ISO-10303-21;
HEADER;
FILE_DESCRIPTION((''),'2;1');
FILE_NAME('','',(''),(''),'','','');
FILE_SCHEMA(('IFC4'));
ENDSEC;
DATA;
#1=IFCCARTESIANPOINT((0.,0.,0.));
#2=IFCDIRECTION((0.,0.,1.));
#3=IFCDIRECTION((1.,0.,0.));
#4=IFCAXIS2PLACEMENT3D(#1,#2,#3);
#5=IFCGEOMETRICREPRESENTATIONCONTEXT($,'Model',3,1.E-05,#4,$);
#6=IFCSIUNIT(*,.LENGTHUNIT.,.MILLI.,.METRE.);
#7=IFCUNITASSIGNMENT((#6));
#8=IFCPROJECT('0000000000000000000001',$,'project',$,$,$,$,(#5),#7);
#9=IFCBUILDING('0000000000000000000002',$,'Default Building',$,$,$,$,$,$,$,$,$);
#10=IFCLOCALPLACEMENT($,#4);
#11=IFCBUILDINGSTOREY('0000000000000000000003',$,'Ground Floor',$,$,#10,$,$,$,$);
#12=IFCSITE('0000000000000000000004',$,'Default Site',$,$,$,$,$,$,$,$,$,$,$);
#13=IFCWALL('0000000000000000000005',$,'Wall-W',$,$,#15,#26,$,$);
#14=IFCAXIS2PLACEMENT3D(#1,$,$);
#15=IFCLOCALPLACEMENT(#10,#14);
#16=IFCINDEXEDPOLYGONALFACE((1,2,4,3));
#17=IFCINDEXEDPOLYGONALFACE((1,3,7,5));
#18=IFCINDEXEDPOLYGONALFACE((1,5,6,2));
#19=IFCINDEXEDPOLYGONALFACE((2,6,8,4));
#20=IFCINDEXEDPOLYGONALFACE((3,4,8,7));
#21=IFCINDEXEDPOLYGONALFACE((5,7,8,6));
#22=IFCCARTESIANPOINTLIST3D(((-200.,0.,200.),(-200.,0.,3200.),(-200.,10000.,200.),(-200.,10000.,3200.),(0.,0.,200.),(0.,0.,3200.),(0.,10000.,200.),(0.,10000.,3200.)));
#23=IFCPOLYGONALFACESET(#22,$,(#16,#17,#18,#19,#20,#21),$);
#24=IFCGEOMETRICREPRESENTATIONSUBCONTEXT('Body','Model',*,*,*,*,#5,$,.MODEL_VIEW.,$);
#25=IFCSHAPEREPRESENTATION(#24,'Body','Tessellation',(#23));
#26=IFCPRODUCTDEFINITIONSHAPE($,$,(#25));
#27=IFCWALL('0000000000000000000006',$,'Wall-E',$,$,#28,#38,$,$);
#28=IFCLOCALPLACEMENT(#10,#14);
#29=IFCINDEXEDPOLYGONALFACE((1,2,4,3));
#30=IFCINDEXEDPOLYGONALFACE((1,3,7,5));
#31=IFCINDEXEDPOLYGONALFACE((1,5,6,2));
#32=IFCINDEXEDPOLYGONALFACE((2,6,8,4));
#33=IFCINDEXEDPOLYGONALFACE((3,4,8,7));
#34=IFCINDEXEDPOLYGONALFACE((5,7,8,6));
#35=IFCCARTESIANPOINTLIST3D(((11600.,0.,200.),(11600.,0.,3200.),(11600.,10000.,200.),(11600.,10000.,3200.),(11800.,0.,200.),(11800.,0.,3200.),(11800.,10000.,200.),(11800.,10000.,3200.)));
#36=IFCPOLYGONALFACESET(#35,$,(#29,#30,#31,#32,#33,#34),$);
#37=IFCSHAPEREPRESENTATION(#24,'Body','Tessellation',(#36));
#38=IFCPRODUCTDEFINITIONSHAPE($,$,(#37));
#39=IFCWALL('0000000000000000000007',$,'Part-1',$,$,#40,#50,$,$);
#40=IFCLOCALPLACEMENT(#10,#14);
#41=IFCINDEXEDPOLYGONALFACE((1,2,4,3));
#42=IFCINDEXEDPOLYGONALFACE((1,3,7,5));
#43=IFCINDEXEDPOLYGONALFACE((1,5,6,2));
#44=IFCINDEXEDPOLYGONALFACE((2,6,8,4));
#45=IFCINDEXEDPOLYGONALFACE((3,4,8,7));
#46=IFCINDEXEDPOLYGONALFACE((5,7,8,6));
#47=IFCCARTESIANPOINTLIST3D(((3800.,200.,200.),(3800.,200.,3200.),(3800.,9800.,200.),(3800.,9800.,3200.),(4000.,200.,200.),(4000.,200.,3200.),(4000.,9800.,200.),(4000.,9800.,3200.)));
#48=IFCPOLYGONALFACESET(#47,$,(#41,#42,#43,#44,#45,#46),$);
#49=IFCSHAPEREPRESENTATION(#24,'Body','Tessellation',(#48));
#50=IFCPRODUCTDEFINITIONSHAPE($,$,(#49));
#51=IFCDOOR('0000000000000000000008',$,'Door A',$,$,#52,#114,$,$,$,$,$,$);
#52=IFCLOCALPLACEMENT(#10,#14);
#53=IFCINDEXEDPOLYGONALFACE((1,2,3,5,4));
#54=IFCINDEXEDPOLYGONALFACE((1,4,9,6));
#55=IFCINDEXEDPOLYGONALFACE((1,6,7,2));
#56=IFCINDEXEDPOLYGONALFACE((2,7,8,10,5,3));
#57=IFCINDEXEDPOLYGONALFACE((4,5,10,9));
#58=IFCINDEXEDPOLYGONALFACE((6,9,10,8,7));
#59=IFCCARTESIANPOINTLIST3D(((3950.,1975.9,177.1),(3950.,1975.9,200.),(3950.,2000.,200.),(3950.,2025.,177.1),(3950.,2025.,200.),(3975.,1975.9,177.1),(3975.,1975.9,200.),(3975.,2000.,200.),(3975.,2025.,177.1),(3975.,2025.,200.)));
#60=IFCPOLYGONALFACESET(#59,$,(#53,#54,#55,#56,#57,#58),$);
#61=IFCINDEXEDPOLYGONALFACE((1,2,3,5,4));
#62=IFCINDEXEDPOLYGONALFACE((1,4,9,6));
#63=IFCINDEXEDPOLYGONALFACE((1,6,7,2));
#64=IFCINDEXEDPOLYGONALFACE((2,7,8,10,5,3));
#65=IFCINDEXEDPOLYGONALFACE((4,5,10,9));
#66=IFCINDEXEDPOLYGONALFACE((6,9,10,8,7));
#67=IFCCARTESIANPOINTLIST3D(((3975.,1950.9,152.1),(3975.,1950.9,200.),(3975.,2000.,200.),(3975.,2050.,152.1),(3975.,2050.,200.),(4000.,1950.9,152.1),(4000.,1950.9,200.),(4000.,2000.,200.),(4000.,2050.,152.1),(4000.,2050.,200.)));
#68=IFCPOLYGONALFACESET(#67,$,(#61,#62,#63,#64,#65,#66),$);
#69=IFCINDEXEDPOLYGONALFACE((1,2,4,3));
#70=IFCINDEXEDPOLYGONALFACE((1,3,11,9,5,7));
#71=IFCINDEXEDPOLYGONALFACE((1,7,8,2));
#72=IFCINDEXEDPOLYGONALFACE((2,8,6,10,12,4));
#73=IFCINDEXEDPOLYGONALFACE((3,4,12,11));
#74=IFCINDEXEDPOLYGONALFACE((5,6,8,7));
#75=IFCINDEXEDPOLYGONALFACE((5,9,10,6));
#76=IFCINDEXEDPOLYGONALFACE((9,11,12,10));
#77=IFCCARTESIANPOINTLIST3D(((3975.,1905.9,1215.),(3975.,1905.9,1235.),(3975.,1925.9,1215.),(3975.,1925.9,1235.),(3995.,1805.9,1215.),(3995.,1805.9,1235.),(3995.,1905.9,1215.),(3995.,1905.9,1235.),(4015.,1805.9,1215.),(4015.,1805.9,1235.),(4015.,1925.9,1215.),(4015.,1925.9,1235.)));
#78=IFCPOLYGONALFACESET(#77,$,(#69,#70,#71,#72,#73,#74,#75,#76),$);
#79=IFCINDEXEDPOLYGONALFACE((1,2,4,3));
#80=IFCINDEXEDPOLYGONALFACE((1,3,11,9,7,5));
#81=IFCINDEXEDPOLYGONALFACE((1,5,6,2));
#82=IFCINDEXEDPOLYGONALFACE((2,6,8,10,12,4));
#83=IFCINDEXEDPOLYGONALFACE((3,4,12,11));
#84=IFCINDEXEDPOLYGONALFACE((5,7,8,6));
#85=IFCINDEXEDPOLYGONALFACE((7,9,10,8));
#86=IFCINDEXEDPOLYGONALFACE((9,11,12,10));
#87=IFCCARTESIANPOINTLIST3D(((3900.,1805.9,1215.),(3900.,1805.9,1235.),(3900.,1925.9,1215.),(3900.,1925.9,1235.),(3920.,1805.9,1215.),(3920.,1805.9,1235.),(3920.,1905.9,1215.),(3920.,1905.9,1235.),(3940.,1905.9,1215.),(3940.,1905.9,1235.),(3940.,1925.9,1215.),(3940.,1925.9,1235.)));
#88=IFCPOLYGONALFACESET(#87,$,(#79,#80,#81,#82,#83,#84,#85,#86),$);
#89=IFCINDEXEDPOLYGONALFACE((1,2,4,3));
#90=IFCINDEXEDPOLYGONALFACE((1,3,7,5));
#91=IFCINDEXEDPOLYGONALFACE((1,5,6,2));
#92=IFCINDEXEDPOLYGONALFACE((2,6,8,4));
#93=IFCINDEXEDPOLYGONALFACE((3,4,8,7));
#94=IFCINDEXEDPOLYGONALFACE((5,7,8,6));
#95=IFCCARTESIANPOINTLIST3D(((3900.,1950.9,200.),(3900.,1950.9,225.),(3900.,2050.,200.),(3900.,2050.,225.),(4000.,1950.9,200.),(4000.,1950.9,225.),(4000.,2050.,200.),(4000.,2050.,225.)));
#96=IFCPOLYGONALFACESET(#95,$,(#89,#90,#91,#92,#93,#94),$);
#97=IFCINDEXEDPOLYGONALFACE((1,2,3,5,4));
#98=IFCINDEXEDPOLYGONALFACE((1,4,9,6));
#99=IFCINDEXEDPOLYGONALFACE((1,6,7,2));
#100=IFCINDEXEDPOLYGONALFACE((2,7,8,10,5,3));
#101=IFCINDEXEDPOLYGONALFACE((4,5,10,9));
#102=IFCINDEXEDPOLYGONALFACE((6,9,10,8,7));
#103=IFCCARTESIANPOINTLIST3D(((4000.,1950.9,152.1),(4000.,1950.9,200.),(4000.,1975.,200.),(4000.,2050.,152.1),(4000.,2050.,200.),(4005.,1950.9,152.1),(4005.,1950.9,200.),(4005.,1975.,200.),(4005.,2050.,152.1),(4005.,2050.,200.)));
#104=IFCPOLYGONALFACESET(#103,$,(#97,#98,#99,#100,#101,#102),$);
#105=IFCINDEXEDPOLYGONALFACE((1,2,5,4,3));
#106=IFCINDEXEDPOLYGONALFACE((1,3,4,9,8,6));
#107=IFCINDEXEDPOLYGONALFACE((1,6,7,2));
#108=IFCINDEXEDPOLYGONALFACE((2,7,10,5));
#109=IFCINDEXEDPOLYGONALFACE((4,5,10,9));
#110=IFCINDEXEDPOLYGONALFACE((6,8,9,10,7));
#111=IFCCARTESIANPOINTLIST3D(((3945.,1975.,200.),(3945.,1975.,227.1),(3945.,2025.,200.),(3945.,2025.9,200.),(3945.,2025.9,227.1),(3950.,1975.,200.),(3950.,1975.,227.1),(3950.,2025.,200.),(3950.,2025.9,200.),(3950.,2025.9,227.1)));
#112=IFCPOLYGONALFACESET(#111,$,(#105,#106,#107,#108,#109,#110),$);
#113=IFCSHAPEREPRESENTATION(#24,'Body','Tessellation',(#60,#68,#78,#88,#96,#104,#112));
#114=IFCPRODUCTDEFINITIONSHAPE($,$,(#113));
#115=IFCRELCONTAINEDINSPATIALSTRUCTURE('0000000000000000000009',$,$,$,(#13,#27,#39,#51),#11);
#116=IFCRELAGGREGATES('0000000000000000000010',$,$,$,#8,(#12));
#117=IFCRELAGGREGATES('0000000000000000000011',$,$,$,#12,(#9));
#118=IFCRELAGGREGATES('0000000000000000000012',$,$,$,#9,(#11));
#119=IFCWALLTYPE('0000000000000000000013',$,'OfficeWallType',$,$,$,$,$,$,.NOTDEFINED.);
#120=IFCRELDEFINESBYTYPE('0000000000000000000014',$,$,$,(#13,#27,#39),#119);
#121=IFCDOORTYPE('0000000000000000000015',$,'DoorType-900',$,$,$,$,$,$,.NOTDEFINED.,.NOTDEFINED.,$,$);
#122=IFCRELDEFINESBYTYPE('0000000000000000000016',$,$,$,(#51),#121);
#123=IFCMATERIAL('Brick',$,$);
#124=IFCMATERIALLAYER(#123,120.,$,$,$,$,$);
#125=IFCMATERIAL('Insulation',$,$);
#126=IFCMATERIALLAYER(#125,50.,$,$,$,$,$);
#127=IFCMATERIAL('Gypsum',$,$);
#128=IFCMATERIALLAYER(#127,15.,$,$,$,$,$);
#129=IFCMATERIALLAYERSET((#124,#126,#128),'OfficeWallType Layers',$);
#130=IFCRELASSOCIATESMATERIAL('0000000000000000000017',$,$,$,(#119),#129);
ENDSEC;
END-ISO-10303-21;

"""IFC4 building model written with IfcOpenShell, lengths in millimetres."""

from ifc_helpers import new_model, si_unit, frame, origin_with_axes, place, context, subcontext, project, spatial, line, indexed_curve, outline, extrude, material, layer, layer_set, type_object, element, fill, save


model = new_model("IFC4")

# Units and contexts
model_context = context("Model", 3, precision=1e-05, world=origin_with_axes())
body_context = subcontext(model_context, "Body", "Model", "MODEL_VIEW")
ifc_project = project(units=[si_unit("LENGTHUNIT", "METRE", prefix="MILLI")], contexts=[model_context])

# Site, building, storey
site = spatial("IfcSite", under=ifc_project, Name="Default Site")
building = spatial("IfcBuilding", under=site, Name="Default Building")
storey_placement = place(None, origin_with_axes())
storey = spatial("IfcBuildingStorey", under=building, at=storey_placement, Name="Ground Floor")

# Shared definitions
ifc_material_1 = material(Name="Brick")
ifc_layer_1 = layer(ifc_material_1, 120.0)
ifc_material_2 = material(Name="Insulation")
ifc_layer_2 = layer(ifc_material_2, 50.0)
ifc_material_3 = material(Name="Gypsum")
ifc_layer_3 = layer(ifc_material_3, 15.0)
ifc_layer_set_1 = layer_set([ifc_layer_1, ifc_layer_2, ifc_layer_3], Name="OfficeWallType Layers")
wall_type = type_object("IfcWallType", Name="OfficeWallType", PredefinedType="NOTDEFINED", material=ifc_layer_set_1)
door_type = type_object("IfcDoorType", Name="DoorType-900", OperationType="NOTDEFINED", PredefinedType="NOTDEFINED")

# Walls
wall_1_placement = place(storey_placement, frame((0.0, 0.0, 200.0), z_axis=(0.0, 0.0, 1.0), x_axis=(1.0, 0.0, 0.0)))
element("IfcWall", 1, at=wall_1_placement, inside=storey, type_object=wall_type, Name="Wall-W", context=body_context, shape_type="SweptSolid", body=[
    extrude(outline(indexed_curve([(0.0, 0.0), (0.0, 10000.0), (-200.0, 10000.0), (-200.0, 0.0), (0.0, 0.0)])), None, (0.0, 0.0, 1.0), 3000.0),
])
wall_2_placement = place(storey_placement, frame((0.0, 0.0, 200.0), z_axis=(0.0, 0.0, 1.0), x_axis=(1.0, 0.0, 0.0)))
element("IfcWall", 2, at=wall_2_placement, inside=storey, type_object=wall_type, Name="Wall-E", context=body_context, shape_type="SweptSolid", body=[
    extrude(outline(indexed_curve([(11800.0, 0.0), (11800.0, 10000.0), (11600.0, 10000.0), (11600.0, 0.0), (11800.0, 0.0)])), None, (0.0, 0.0, 1.0), 3000.0),
])

# Wall, opening, door
wall_3_placement = place(storey_placement, frame((0.0, 0.0, 200.0), z_axis=(0.0, 0.0, 1.0), x_axis=(1.0, 0.0, 0.0)))
wall_3 = element("IfcWall", 3, at=wall_3_placement, inside=storey, type_object=wall_type, Name="Part-1", context=body_context, shape_type="SweptSolid", body=[
    extrude(outline(indexed_curve([(4000.0, 200.0), (4000.0, 9800.0), (3800.0, 9800.0), (3800.0, 200.0), (4000.0, 200.0)])), None, (0.0, 0.0, 1.0), 3000.0),
])
opening_1_placement = place(wall_3_placement, origin_with_axes())
opening_1 = element("IfcOpeningElement", 4, at=opening_1_placement, cuts=wall_3, context=body_context, shape_type="SweptSolid", body=[
    extrude(outline(indexed_curve([(4000.0, 2000.0), (4200.0, 2000.0), (4200.0, 2900.0), (4000.0, 2900.0), (4000.0, 2000.0)])), None, (0.0, 0.0, 1.0), 2100.0),
])
door_1_placement = place(storey_placement, frame((4000.0, 2000.0, 200.0), z_axis=(0.0, 0.0, 1.0), x_axis=(0.0, 1.0, 0.0)))
door_1 = element("IfcDoor", 5, at=door_1_placement, inside=storey, type_object=door_type, Name="Door A", context=body_context, shape_type="SweptSolid", body=[
    extrude(outline(indexed_curve([(0.0, 0.0), (0.0, 2.1), (0.9, 2.1), (0.9, 0.0), (-24.1, 0.0), (-24.1, -22.9), (25.0, -22.9), (25.0, 0.0)], segments=[line(1, 2, 3, 4, 5, 6, 7, 8, 1)])), frame((0.0, 25.0, 0.0), z_axis=(0.0, -1.0, 0.0), x_axis=(1.0, 0.0, 0.0)), (0.0, 0.0, -1.0), 25.0),
    extrude(outline(indexed_curve([(0.0, 0.0), (0.0, 2.1), (0.9, 2.1), (0.9, 0.0), (-49.1, 0.0), (-49.1, -47.9), (50.0, -47.9), (50.0, 0.0)], segments=[line(1, 2, 3, 4, 5, 6, 7, 8, 1)])), frame((0.0, 0.0, 0.0), z_axis=(0.0, -1.0, 0.0), x_axis=(1.0, 0.0, 0.0)), (0.0, 0.0, -1.0), 25.0),
    extrude(outline(indexed_curve([(0.0, 0.0), (-49.1, 0.0), (-49.1, 35.0), (0.0, 35.0)], segments=[line(1, 2, 3, 4, 1)])), frame((25.0, 25.0, 25.0), z_axis=(0.0, 0.0, 1.0), x_axis=(1.0, 0.0, 0.0)), (0.0, 0.0, 1.0), -47.9),
    extrude(outline(indexed_curve([(0.0, 0.0), (0.0, -40.0), (-120.0, -40.0), (-120.0, -20.0), (-20.0, -20.0), (-20.0, 0.0)], segments=[line(1, 2, 3, 4, 5, 6, 1)])), frame((-74.1, 25.0, 1015.0), z_axis=(0.0, 0.0, 1.0), x_axis=(1.0, 0.0, 0.0)), (0.0, 0.0, 1.0), 20.0),
    extrude(outline(indexed_curve([(0.0, 0.0), (0.0, 40.0), (-120.0, 40.0), (-120.0, 20.0), (-20.0, 20.0), (-20.0, 0.0)], segments=[line(1, 2, 3, 4, 5, 6, 1)])), frame((-74.1, 60.0, 1015.0), z_axis=(0.0, 0.0, 1.0), x_axis=(1.0, 0.0, 0.0)), (0.0, 0.0, 1.0), 20.0),
    extrude(outline(indexed_curve([(0.0, 0.0), (-99.1, 0.0), (-99.1, 100.0), (0.0, 100.0)], segments=[line(1, 2, 3, 4, 1)])), frame((50.0, 0.0, 0.0), z_axis=(0.0, 0.0, 1.0), x_axis=(1.0, 0.0, 0.0)), (0.0, 0.0, 1.0), 25.0),
    extrude(outline(indexed_curve([(0.0, 0.0), (0.0, 27.1), (50.9, 27.1), (50.9, 0.0), (-24.1, 0.0), (-24.1, -47.9), (75.0, -47.9), (75.0, 0.0)], segments=[line(1, 2, 3, 4, 5, 6, 7, 8, 1)])), frame((-25.0, -5.0, 0.0), z_axis=(0.0, -1.0, 0.0), x_axis=(1.0, 0.0, 0.0)), (0.0, 0.0, -1.0), 5.0),
    extrude(outline(indexed_curve([(0.0, 0.0), (0.0, 27.1), (50.9, 27.1), (50.9, 0.0), (0.9, 0.0), (0.9, -22.9), (50.0, -22.9), (50.0, 0.0)], segments=[line(1, 2, 3, 4, 5, 6, 7, 8, 1)])), frame((-25.0, 50.0, 0.0), z_axis=(0.0, -1.0, 0.0), x_axis=(1.0, 0.0, 0.0)), (0.0, 0.0, -1.0), 5.0),
])
fill(opening_1, door_1)

save(model, "model.ifc")
